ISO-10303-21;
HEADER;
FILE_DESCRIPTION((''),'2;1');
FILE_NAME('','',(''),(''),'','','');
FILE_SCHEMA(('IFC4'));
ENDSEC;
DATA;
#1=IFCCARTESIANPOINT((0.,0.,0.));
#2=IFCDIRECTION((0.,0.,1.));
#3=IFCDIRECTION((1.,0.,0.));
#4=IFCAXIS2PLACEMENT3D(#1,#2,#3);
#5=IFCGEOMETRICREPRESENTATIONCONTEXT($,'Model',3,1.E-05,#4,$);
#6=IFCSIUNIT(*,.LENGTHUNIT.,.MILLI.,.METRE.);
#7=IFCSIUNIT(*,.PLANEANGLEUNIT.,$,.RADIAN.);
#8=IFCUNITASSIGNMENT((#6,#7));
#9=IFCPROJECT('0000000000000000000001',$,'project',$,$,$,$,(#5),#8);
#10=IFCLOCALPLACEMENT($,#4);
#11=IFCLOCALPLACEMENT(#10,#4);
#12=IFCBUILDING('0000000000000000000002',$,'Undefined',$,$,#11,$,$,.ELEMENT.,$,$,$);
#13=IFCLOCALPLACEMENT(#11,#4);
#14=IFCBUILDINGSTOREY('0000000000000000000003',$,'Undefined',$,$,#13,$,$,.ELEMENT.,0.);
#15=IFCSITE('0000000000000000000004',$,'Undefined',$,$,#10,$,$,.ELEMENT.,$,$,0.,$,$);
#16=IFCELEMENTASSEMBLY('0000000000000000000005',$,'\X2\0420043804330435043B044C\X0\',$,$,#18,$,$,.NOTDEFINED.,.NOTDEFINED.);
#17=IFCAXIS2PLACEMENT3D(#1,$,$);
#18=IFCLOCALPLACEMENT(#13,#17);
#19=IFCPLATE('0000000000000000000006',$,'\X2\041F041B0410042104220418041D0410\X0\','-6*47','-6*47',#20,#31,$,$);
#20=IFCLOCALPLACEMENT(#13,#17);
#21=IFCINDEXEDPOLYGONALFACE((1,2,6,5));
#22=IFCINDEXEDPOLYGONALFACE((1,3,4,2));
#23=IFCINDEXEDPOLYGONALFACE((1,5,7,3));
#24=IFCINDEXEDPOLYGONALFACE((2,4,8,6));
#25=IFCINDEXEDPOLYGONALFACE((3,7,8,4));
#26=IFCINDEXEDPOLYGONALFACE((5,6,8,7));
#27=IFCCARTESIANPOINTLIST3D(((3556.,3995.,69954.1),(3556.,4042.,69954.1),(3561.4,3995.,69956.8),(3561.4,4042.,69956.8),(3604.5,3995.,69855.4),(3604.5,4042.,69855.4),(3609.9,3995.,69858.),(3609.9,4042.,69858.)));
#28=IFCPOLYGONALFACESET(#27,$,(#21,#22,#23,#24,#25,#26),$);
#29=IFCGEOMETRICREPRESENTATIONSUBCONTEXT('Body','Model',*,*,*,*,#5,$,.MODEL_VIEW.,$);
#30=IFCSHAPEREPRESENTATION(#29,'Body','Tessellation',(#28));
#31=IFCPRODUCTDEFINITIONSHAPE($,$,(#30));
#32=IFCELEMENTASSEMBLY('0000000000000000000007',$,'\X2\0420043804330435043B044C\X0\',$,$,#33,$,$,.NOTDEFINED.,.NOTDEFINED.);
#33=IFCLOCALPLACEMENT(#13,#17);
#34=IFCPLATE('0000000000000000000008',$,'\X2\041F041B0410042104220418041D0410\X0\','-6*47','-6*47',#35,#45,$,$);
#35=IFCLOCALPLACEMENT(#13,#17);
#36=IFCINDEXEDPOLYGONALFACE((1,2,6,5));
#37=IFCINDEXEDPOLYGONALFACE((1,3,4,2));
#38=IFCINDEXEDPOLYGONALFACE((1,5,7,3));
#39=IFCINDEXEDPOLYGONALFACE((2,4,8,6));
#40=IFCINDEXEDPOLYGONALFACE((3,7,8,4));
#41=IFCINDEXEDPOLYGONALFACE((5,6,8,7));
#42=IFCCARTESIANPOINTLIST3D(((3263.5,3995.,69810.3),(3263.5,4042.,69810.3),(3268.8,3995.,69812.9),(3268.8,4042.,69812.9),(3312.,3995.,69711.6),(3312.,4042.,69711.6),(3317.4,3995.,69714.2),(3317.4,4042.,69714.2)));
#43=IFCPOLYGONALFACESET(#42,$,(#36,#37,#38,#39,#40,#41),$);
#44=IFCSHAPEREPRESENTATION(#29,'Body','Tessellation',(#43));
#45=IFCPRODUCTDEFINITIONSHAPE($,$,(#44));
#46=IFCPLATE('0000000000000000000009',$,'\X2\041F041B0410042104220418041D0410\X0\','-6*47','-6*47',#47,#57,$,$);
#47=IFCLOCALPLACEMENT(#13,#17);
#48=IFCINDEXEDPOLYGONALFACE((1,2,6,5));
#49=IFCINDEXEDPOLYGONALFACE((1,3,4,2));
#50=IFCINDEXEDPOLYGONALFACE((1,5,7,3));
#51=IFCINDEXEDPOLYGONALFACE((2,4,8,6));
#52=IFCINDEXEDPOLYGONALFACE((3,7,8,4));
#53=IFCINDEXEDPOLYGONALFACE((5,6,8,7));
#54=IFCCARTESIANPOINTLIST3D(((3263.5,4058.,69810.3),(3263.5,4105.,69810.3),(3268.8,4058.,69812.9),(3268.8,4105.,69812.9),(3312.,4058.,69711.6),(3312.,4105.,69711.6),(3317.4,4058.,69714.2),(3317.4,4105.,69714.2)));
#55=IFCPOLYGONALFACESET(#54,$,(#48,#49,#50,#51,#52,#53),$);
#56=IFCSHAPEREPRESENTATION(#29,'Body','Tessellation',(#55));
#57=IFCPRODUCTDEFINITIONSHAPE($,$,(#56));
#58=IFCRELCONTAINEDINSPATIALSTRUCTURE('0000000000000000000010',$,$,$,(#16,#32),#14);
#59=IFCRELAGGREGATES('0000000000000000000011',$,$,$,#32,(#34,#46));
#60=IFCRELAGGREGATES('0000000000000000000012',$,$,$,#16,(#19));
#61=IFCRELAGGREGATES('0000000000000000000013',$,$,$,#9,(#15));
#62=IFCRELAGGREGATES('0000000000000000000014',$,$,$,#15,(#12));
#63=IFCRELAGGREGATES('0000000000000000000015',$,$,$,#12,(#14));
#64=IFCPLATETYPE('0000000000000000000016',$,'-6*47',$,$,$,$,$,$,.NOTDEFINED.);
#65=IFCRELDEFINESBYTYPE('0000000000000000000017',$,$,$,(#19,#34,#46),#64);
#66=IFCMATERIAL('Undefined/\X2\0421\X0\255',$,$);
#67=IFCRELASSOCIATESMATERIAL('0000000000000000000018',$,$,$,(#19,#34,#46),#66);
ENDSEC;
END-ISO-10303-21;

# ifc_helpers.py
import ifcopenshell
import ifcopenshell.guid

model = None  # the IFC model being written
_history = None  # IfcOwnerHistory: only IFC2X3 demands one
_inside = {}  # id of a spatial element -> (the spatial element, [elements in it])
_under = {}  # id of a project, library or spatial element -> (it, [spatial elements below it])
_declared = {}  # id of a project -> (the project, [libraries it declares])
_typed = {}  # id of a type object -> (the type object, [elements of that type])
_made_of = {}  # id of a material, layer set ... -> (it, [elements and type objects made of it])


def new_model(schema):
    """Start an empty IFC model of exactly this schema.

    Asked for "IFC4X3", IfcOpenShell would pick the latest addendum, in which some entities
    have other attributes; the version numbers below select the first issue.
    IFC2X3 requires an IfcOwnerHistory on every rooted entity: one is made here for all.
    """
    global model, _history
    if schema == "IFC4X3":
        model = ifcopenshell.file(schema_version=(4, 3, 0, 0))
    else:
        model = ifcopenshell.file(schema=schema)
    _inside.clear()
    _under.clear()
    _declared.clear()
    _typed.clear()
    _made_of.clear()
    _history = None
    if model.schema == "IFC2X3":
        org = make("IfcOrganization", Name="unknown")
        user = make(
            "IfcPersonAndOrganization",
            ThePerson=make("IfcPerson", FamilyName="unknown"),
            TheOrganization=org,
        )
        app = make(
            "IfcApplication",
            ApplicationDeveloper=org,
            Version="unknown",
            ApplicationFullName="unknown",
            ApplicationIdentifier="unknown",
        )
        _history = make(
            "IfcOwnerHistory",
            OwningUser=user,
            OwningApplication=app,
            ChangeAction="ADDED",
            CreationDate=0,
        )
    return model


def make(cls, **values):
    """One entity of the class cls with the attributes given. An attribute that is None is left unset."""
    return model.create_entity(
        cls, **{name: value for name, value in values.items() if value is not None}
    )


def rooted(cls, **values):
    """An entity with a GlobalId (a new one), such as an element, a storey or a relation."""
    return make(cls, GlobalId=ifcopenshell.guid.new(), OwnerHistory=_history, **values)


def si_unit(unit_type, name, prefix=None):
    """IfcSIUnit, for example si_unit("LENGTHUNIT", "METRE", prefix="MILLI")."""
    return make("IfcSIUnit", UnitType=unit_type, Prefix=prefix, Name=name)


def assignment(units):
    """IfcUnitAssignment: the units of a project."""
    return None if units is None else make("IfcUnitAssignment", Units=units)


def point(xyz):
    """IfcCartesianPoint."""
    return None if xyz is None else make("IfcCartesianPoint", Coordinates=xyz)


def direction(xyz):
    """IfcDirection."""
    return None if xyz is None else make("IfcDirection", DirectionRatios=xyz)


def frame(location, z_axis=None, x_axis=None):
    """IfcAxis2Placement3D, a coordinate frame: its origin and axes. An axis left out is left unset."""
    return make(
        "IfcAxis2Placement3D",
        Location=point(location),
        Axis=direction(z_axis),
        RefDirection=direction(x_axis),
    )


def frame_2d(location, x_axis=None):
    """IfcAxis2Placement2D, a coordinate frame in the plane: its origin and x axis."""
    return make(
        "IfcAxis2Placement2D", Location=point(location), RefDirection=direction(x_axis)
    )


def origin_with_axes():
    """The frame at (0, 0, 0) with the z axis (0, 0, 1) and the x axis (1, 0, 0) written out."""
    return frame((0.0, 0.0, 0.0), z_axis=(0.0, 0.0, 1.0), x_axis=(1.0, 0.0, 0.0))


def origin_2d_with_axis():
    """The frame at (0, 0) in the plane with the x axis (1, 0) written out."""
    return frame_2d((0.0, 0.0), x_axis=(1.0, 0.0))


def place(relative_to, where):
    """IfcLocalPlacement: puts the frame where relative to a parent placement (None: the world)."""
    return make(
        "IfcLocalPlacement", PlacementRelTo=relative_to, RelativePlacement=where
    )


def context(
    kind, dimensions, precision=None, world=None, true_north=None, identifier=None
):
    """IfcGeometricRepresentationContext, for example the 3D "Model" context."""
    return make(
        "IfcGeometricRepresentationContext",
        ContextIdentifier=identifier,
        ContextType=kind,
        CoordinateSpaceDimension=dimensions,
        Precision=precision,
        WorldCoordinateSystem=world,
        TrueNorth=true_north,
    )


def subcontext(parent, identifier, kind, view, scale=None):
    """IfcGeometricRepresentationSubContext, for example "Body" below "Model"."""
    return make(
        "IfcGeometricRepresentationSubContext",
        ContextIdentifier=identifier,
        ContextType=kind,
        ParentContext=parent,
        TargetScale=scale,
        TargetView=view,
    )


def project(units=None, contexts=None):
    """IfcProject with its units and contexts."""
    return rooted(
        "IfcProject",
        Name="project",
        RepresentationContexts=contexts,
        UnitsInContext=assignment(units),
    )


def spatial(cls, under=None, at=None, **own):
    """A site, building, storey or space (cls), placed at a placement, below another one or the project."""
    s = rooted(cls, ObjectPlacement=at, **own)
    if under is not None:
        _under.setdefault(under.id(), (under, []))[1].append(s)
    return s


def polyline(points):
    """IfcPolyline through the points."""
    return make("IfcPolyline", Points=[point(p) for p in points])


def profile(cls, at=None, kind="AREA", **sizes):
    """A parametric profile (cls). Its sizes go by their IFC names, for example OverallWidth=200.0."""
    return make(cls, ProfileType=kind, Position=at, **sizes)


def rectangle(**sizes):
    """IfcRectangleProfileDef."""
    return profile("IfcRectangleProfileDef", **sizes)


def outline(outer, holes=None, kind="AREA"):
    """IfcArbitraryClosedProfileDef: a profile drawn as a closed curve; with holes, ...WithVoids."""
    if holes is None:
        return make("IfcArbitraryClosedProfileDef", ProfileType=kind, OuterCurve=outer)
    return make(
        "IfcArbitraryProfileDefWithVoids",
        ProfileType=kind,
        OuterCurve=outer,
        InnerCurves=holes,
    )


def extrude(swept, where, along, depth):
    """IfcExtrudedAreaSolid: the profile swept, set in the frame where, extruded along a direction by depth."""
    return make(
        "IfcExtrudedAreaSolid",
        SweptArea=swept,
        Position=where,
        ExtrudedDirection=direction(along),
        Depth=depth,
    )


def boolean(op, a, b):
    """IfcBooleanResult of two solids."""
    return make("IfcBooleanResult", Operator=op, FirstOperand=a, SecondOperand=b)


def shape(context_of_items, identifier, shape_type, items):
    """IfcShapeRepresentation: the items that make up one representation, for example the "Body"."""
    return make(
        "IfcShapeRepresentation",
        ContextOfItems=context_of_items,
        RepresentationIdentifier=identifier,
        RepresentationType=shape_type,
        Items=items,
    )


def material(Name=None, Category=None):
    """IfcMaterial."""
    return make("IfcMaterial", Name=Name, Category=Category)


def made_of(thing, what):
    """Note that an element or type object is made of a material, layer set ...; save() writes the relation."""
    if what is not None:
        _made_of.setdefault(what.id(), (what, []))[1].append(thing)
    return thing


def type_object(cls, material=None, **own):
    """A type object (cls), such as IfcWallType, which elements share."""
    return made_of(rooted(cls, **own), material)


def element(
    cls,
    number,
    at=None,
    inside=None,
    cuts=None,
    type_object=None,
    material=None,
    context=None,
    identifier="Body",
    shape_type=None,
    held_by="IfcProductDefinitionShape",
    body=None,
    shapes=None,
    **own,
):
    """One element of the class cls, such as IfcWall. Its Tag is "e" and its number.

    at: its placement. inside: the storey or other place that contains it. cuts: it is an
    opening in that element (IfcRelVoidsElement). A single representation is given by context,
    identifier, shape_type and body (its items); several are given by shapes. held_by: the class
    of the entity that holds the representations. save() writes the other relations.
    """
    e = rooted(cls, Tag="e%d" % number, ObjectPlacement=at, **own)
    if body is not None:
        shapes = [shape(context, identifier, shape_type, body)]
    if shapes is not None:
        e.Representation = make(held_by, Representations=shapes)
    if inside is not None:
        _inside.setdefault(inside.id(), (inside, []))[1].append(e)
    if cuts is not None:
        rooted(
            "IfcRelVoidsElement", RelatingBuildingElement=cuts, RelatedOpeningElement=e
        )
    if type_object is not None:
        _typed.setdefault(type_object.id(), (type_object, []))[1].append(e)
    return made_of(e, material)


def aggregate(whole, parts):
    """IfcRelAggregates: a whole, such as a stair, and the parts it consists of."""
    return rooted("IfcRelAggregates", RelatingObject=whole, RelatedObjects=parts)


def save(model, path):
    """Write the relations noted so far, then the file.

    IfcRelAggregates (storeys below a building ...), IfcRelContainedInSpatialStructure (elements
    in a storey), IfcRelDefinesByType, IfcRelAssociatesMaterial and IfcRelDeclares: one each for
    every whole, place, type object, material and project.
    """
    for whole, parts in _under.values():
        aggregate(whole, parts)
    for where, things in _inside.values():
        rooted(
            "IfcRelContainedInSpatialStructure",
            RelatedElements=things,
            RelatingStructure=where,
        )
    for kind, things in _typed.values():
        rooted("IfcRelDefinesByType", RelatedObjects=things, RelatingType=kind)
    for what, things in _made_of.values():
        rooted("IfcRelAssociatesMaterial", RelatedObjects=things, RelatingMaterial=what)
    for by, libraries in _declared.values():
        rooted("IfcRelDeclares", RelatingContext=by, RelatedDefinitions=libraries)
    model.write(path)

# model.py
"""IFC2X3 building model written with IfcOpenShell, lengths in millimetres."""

from ifc_helpers import new_model, si_unit, frame, origin_with_axes, origin_2d_with_axis, place, context, subcontext, project, spatial, polyline, rectangle, outline, extrude, boolean, material, type_object, element, aggregate, save


model = new_model("IFC2X3")

# Units and contexts
model_context = context("Model", 3, precision=1e-05, world=origin_with_axes())
body_context = subcontext(model_context, "Body", "Model", "MODEL_VIEW")
ifc_project = project(units=[si_unit("LENGTHUNIT", "METRE", prefix="MILLI"), si_unit("PLANEANGLEUNIT", "RADIAN")], contexts=[model_context])

# Site, building, storey
site_placement = place(None, origin_with_axes())
site = spatial("IfcSite", under=ifc_project, at=site_placement, Name="Undefined", CompositionType="ELEMENT", RefElevation=0.0)
building_placement = place(site_placement, origin_with_axes())
building = spatial("IfcBuilding", under=site, at=building_placement, Name="Undefined", CompositionType="ELEMENT")
storey_placement = place(building_placement, origin_with_axes())
storey = spatial("IfcBuildingStorey", under=building, at=storey_placement, Name="Undefined", CompositionType="ELEMENT", Elevation=0.0)

# Shared definitions
ifc_material_1 = material(Name="Undefined/С255")

# Element assembly
assembly_1_placement = place(storey_placement, origin_with_axes())
assembly_1 = element("IfcElementAssembly", 1, at=assembly_1_placement, inside=storey, Name="Ригель", AssemblyPlace="NOTDEFINED", PredefinedType="NOTDEFINED")

# Shared definitions
plate_type = type_object("IfcPlateType", Name="-6*47", PredefinedType="NOTDEFINED")

# Plate
plate_1_placement = place(assembly_1_placement, frame((3607.2, 3995.0, 69856.7), z_axis=(-0.897399, 0.0, -0.441221), x_axis=(-0.441221, 0.0, 0.897399)))
plate_1 = element("IfcPlate", 2, at=plate_1_placement, type_object=plate_type, material=ifc_material_1, Name="ПЛАСТИНА", Description="-6*47", ObjectType="-6*47", context=body_context, shape_type="CSG", body=[
    boolean("DIFFERENCE", extrude(outline(polyline([(0.0, 0.0), (110.0, 0.0), (110.0, 110.0), (0.0, 110.0), (0.0, 0.0)])), frame((0.0, 0.0, -3.0), z_axis=(0.0, 0.0, 1.0), x_axis=(1.0, 0.0, 0.0)), (0.0, 0.0, 1.0), 6.0), extrude(rectangle(XDim=26.0, YDim=130.0, at=origin_2d_with_axis()), frame((55.0, 47.0, 0.0), z_axis=(0.0, 1.0, 0.0), x_axis=(0.0, 0.0, -1.0)), (0.0, 0.0, 1.0), 66.0)),
])

# Element assembly, plates
assembly_2_placement = place(storey_placement, origin_with_axes())
assembly_2 = element("IfcElementAssembly", 3, at=assembly_2_placement, inside=storey, Name="Ригель", AssemblyPlace="NOTDEFINED", PredefinedType="NOTDEFINED")
plate_2_placement = place(assembly_2_placement, frame((3266.1, 3995.0, 69811.6), z_axis=(0.897399, 0.0, 0.441221), x_axis=(0.441221, 0.0, -0.897399)))
plate_2 = element("IfcPlate", 4, at=plate_2_placement, type_object=plate_type, material=ifc_material_1, Name="ПЛАСТИНА", Description="-6*47", ObjectType="-6*47", context=body_context, shape_type="CSG", body=[
    boolean("DIFFERENCE", extrude(outline(polyline([(0.0, 0.0), (110.0, 0.0), (110.0, 110.0), (0.0, 110.0), (0.0, 0.0)])), frame((0.0, 0.0, -3.0), z_axis=(0.0, 0.0, 1.0), x_axis=(1.0, 0.0, 0.0)), (0.0, 0.0, 1.0), 6.0), extrude(rectangle(XDim=26.0, YDim=130.0, at=origin_2d_with_axis()), frame((55.0, 47.0, 0.0), z_axis=(0.0, 1.0, 0.0), x_axis=(0.0, 0.0, -1.0)), (0.0, 0.0, 1.0), 66.0)),
])
plate_3_placement = place(assembly_2_placement, frame((3266.1, 3995.0, 69811.6), z_axis=(0.897399, 0.0, 0.441221), x_axis=(0.441221, 0.0, -0.897399)))
plate_3 = element("IfcPlate", 5, at=plate_3_placement, type_object=plate_type, material=ifc_material_1, Name="ПЛАСТИНА", Description="-6*47", ObjectType="-6*47", context=body_context, shape_type="CSG", body=[
    boolean("DIFFERENCE", extrude(outline(polyline([(0.0, 0.0), (110.0, 0.0), (110.0, 110.0), (0.0, 110.0), (0.0, 0.0)])), frame((0.0, 0.0, -3.0), z_axis=(0.0, 0.0, 1.0), x_axis=(1.0, 0.0, 0.0)), (0.0, 0.0, 1.0), 6.0), extrude(rectangle(XDim=26.0, YDim=130.0, at=origin_2d_with_axis()), frame((55.0, -3.0, 0.0), z_axis=(0.0, 1.0, 0.0), x_axis=(0.0, 0.0, -1.0)), (0.0, 0.0, 1.0), 66.0)),
])
aggregate(assembly_2, [plate_2, plate_3])

aggregate(assembly_1, [plate_1])

save(model, "model.ifc")
